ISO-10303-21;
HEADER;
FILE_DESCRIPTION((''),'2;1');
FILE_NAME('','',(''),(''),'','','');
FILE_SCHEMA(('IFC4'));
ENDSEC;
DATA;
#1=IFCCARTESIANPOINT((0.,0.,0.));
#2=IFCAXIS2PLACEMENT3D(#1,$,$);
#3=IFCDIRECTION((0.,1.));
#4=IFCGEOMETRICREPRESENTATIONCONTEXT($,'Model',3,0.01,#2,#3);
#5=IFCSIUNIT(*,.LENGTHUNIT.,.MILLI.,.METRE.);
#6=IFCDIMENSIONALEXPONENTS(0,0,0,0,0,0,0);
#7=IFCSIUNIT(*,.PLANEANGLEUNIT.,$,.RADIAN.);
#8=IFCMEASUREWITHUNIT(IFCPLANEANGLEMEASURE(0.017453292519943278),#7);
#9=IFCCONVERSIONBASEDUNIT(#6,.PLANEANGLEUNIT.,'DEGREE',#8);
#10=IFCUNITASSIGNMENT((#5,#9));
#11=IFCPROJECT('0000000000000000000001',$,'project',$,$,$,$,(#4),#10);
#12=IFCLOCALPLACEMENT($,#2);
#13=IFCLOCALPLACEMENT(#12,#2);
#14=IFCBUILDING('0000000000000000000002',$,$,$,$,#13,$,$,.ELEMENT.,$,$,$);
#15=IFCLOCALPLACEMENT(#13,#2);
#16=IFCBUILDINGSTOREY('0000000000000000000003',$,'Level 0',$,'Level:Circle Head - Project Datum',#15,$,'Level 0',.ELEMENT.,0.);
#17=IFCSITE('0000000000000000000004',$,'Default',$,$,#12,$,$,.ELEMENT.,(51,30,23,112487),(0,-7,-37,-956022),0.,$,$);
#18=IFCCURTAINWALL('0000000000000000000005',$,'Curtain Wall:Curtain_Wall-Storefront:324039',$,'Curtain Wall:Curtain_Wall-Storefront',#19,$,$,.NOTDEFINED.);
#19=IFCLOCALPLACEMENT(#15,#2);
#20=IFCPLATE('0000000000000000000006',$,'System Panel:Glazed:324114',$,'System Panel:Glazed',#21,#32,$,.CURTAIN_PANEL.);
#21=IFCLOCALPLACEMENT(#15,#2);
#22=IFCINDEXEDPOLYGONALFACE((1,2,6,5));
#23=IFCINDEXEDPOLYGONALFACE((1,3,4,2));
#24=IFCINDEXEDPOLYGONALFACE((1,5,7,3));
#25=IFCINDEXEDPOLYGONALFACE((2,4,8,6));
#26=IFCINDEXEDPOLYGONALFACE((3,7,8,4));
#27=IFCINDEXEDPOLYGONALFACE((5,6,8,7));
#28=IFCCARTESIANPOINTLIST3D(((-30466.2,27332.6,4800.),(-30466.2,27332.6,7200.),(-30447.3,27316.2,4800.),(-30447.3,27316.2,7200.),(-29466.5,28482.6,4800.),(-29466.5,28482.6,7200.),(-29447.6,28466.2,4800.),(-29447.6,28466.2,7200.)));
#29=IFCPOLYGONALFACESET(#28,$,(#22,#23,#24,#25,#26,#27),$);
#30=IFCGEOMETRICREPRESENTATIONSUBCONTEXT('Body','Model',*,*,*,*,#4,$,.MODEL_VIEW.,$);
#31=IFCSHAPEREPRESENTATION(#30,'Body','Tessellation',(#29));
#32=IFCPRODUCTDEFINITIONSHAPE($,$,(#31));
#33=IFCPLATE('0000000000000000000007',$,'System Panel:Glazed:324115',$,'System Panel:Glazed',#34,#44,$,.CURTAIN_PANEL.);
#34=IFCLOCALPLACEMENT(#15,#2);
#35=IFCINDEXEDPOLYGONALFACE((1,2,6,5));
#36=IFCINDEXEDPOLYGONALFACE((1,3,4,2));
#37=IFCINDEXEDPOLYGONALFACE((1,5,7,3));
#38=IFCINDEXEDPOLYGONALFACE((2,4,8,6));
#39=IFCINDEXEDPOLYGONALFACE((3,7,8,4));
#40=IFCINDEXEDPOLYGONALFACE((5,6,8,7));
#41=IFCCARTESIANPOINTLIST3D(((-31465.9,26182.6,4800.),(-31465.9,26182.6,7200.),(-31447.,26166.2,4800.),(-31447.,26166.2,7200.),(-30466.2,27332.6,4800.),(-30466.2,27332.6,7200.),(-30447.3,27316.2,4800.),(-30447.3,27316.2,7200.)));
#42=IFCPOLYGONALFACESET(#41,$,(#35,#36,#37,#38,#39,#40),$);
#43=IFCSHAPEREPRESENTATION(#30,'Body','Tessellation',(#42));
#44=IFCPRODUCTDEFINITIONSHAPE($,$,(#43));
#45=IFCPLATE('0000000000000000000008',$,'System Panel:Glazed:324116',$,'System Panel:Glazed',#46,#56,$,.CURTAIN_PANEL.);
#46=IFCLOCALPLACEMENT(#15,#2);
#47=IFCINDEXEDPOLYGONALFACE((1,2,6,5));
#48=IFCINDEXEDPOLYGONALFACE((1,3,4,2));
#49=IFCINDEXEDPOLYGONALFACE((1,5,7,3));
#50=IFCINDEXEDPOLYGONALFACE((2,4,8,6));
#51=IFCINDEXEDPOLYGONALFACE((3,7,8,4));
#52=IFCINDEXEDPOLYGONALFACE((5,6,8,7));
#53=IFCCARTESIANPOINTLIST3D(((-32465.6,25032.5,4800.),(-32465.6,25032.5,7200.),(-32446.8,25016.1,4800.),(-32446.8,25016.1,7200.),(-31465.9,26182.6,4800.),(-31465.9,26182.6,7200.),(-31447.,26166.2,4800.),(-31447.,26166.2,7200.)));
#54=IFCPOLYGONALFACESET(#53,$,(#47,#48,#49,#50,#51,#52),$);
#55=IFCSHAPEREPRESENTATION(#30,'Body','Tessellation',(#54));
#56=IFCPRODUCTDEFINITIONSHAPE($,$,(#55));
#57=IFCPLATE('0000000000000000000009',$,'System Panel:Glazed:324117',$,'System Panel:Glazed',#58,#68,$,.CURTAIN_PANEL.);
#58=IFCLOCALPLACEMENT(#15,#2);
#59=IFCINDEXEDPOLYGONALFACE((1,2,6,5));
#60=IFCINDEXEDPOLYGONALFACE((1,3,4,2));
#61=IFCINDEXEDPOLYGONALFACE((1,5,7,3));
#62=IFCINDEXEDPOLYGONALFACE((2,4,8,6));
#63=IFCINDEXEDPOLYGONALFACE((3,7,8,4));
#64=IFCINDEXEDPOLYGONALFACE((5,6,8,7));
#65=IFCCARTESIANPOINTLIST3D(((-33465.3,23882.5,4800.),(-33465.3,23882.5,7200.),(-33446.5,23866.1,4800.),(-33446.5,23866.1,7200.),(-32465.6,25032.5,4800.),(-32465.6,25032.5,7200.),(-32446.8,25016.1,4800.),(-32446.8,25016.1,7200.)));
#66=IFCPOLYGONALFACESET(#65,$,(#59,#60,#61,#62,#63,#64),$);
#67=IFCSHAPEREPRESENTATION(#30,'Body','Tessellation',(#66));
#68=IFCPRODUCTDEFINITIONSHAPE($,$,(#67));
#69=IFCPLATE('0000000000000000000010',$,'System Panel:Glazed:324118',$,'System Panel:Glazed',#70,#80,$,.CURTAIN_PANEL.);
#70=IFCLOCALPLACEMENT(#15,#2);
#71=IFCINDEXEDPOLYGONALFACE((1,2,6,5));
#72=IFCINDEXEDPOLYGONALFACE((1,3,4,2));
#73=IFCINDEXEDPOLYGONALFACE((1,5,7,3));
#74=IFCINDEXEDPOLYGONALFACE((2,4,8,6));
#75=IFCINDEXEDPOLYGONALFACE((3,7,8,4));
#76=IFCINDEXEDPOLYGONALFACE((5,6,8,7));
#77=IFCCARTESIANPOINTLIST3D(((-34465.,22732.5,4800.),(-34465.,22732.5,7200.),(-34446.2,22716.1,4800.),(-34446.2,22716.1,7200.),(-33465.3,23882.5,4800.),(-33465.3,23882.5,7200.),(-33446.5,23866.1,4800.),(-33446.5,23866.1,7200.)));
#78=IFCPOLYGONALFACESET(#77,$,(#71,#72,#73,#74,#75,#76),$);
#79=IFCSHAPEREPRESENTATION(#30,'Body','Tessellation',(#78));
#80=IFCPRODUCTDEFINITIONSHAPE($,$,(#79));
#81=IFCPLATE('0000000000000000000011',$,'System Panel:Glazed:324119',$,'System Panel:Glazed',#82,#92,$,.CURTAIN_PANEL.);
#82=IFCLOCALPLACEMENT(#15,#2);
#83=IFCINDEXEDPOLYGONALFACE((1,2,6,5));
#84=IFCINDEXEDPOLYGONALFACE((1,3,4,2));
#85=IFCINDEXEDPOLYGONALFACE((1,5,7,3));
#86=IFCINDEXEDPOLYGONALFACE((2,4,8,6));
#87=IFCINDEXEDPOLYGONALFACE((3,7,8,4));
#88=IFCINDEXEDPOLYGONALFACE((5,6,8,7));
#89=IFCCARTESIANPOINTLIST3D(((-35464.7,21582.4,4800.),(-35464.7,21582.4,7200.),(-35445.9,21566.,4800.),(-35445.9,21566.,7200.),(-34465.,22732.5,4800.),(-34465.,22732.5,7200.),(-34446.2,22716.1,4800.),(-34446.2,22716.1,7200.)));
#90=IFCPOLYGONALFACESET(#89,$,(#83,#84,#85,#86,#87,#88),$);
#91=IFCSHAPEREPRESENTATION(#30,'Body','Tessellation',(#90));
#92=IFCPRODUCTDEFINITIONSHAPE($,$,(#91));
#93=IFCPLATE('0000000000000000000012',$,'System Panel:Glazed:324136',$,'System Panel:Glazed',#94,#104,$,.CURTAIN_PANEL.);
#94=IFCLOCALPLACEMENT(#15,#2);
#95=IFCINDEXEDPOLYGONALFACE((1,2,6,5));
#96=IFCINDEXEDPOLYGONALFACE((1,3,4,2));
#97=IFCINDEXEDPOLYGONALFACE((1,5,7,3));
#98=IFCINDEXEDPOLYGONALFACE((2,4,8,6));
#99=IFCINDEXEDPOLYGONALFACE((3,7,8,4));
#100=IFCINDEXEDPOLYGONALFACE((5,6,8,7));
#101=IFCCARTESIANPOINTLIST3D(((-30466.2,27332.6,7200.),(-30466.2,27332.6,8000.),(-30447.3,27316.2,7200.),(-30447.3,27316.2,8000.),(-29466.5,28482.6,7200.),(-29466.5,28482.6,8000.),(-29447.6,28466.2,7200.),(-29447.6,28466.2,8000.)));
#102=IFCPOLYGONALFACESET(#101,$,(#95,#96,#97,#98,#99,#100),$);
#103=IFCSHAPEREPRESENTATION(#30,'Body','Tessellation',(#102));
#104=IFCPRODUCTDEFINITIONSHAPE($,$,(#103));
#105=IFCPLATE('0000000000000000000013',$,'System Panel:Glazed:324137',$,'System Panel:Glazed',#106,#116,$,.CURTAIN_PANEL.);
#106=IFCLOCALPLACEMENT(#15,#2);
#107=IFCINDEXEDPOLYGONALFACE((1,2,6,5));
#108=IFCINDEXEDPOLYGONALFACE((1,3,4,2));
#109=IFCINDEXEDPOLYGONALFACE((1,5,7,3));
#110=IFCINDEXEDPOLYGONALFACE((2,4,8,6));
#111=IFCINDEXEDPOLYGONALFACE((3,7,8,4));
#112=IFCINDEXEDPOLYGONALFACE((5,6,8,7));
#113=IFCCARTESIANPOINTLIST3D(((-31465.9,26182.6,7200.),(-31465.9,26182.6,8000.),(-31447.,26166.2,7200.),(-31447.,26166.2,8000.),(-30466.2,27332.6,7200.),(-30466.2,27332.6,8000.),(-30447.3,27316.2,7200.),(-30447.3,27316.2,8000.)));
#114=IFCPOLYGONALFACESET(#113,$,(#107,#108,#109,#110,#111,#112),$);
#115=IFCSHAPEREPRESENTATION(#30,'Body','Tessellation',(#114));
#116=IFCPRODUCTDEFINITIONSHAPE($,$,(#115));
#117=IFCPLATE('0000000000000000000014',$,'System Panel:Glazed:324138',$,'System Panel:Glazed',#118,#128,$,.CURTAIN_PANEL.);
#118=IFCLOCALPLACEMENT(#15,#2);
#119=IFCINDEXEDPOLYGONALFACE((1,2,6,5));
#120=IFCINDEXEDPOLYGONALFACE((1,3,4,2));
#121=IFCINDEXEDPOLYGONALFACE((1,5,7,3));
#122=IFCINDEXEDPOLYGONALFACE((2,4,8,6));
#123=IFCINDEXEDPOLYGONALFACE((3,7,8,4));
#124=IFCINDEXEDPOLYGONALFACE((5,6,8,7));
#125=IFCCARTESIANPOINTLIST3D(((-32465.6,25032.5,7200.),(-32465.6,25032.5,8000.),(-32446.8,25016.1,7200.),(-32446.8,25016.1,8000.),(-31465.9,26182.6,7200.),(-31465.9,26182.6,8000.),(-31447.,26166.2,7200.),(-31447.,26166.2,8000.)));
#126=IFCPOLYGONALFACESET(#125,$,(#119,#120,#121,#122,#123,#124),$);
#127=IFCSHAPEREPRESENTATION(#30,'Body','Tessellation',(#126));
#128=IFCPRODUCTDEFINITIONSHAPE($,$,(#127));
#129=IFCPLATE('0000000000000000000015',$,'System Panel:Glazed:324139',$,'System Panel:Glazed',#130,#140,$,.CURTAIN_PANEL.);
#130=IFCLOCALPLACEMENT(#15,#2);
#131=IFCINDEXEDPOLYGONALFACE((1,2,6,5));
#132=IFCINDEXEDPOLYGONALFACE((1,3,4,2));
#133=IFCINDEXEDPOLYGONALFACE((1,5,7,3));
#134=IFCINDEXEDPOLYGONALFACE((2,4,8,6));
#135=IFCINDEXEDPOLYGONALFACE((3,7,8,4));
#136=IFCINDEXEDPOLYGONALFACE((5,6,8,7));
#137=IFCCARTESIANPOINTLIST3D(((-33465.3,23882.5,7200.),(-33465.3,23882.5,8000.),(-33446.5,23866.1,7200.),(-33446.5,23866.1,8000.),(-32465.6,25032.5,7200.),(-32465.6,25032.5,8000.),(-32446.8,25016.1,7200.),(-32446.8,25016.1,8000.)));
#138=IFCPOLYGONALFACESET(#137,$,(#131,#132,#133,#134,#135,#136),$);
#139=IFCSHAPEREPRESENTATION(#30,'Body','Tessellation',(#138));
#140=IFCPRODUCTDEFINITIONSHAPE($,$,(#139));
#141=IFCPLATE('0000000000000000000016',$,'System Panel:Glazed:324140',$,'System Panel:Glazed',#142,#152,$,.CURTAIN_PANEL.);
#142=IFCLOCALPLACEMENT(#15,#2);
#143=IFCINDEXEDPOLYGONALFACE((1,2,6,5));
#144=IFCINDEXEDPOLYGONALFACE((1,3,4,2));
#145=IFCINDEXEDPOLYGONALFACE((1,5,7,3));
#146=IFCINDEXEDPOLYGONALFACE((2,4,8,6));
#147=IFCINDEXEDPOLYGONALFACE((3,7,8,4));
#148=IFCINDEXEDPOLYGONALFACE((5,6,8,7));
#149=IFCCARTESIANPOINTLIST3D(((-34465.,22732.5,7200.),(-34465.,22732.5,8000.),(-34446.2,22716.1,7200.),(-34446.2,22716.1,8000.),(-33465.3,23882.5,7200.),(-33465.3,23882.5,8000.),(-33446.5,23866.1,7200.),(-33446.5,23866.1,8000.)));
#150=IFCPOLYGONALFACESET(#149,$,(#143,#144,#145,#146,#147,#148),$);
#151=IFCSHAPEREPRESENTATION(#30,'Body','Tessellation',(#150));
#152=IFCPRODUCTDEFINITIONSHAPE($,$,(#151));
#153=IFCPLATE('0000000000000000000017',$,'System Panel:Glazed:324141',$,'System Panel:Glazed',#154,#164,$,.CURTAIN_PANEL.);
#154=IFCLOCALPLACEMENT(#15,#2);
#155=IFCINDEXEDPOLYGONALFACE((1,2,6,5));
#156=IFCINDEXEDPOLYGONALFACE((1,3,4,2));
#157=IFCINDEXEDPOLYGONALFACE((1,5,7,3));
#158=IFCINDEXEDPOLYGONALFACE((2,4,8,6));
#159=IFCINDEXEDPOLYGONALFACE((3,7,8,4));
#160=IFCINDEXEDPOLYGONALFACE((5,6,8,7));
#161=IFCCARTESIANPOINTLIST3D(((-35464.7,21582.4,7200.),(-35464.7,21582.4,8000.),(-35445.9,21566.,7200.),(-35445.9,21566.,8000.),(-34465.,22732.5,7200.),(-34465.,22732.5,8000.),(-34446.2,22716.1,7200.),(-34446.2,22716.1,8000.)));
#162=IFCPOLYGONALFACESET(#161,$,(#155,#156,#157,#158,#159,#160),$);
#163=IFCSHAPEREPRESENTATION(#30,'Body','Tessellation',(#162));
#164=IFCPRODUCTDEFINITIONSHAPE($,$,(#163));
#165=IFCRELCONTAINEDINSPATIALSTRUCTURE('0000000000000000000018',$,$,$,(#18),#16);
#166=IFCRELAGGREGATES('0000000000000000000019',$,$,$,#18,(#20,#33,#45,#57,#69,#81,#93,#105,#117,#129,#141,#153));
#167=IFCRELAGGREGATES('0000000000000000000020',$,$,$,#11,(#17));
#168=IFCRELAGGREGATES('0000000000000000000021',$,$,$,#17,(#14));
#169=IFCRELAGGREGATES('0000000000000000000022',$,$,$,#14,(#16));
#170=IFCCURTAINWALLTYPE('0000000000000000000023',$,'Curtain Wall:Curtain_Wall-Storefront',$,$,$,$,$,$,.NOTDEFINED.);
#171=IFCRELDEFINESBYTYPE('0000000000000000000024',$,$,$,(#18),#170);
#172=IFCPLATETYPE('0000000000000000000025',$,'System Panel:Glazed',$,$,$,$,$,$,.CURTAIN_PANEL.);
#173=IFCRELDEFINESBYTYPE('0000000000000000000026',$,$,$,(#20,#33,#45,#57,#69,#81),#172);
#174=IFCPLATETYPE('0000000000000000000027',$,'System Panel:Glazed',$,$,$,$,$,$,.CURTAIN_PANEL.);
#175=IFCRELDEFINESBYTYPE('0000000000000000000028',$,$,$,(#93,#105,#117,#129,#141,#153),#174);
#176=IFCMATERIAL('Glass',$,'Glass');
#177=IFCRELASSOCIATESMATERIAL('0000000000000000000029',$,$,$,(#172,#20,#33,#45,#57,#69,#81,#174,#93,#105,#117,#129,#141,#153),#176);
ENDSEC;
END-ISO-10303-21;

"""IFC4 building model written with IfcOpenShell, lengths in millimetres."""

from ifc_helpers import new_model, entity, si_unit, converted_unit, direction, frame, origin, place, context, subcontext, project, spatial, indexed_curve, outline, extrude, source, transform, mapped, material, type_object, type_shapes, element, aggregate, save


model = new_model("IFC4")

# Units and contexts
model_context = context("Model", 3, precision=0.01, world=origin(), true_north=direction((0.0, 1.0)))
body_context = subcontext(model_context, "Body", "Model", "MODEL_VIEW")
ifc_project = project(units=[si_unit("LENGTHUNIT", "METRE", prefix="MILLI"), converted_unit("PLANEANGLEUNIT", "DEGREE", entity("IfcPlaneAngleMeasure", 0.017453292519943278), si_unit("PLANEANGLEUNIT", "RADIAN"), dimensions=[0, 0, 0, 0, 0, 0, 0])], contexts=[model_context])

# Site, building, storey
site_placement = place(None, origin())
site = spatial("IfcSite", under=ifc_project, at=site_placement, Name="Default", CompositionType="ELEMENT", RefLatitude=(51, 30, 23, 112487), RefLongitude=(0, -7, -37, -956022), RefElevation=0.0)
building_placement = place(site_placement, origin())
building = spatial("IfcBuilding", under=site, at=building_placement, CompositionType="ELEMENT")
storey_placement = place(building_placement, origin())
storey = spatial("IfcBuildingStorey", under=building, at=storey_placement, Name="Level 0", ObjectType="Level:Circle Head - Project Datum", LongName="Level 0", CompositionType="ELEMENT", Elevation=0.0)

# Curtain wall, plates
curtain_wall_type = type_object("IfcCurtainWallType", Name="Curtain Wall:Curtain_Wall-Storefront", PredefinedType="NOTDEFINED")
curtain_wall_placement = place(storey_placement, origin())
curtain_wall = element("IfcCurtainWall", 1, at=curtain_wall_placement, inside=storey, type_object=curtain_wall_type, Name="Curtain Wall:Curtain_Wall-Storefront:324039", ObjectType="Curtain Wall:Curtain_Wall-Storefront", PredefinedType="NOTDEFINED")
ifc_material = material(Name="Glass", Category="Glass")
plate_type_1 = type_object("IfcPlateType", Name="System Panel:Glazed", PredefinedType="CURTAIN_PANEL", material=ifc_material)
shared_shape_1 = source(origin(), body_context, "Body", "SweptSolid", [
    extrude(outline(indexed_curve([(-12.5, -761.9), (12.5, -761.9), (12.5, 761.9), (-12.5, 761.9), (-12.5, -761.9)], self_intersect=False)), frame((0.0, 37.0, 0.0), z_axis=(0.0, 0.0, 1.0), x_axis=(0.0, 1.0, 0.0)), (0.0, 0.0, 1.0), 2400.0),
])
type_shapes(plate_type_1, [shared_shape_1])
plate_1_placement = place(curtain_wall_placement, frame((-29984.8, 27923.7, 4800.0), z_axis=(0.0, 0.0, 1.0), x_axis=(-0.656059, -0.75471, 0.0)))
plate_1 = element("IfcPlate", 2, at=plate_1_placement, type_object=plate_type_1, material=ifc_material, Name="System Panel:Glazed:324114", ObjectType="System Panel:Glazed", PredefinedType="CURTAIN_PANEL", context=body_context, shape_type="MappedRepresentation", body=[
    mapped(shared_shape_1, transform((0.0, 0.0, 0.0), scale=1.0)),
])
plate_2_placement = place(curtain_wall_placement, frame((-30984.5, 26773.7, 4800.0), z_axis=(0.0, 0.0, 1.0), x_axis=(-0.656059, -0.75471, 0.0)))
plate_2 = element("IfcPlate", 3, at=plate_2_placement, type_object=plate_type_1, material=ifc_material, Name="System Panel:Glazed:324115", ObjectType="System Panel:Glazed", PredefinedType="CURTAIN_PANEL", context=body_context, shape_type="MappedRepresentation", body=[
    mapped(shared_shape_1, transform((0.0, 0.0, 0.0), scale=1.0)),
])
plate_3_placement = place(curtain_wall_placement, frame((-31984.3, 25623.6, 4800.0), z_axis=(0.0, 0.0, 1.0), x_axis=(-0.656059, -0.75471, 0.0)))
plate_3 = element("IfcPlate", 4, at=plate_3_placement, type_object=plate_type_1, material=ifc_material, Name="System Panel:Glazed:324116", ObjectType="System Panel:Glazed", PredefinedType="CURTAIN_PANEL", context=body_context, shape_type="MappedRepresentation", body=[
    mapped(shared_shape_1, transform((0.0, 0.0, 0.0), scale=1.0)),
])
plate_4_placement = place(curtain_wall_placement, frame((-32984.0, 24473.6, 4800.0), z_axis=(0.0, 0.0, 1.0), x_axis=(-0.656059, -0.75471, 0.0)))
plate_4 = element("IfcPlate", 5, at=plate_4_placement, type_object=plate_type_1, material=ifc_material, Name="System Panel:Glazed:324117", ObjectType="System Panel:Glazed", PredefinedType="CURTAIN_PANEL", context=body_context, shape_type="MappedRepresentation", body=[
    mapped(shared_shape_1, transform((0.0, 0.0, 0.0), scale=1.0)),
])
plate_5_placement = place(curtain_wall_placement, frame((-33983.7, 23323.6, 4800.0), z_axis=(0.0, 0.0, 1.0), x_axis=(-0.656059, -0.75471, 0.0)))
plate_5 = element("IfcPlate", 6, at=plate_5_placement, type_object=plate_type_1, material=ifc_material, Name="System Panel:Glazed:324118", ObjectType="System Panel:Glazed", PredefinedType="CURTAIN_PANEL", context=body_context, shape_type="MappedRepresentation", body=[
    mapped(shared_shape_1, transform((0.0, 0.0, 0.0), scale=1.0)),
])
plate_6_placement = place(curtain_wall_placement, frame((-34983.4, 22173.5, 4800.0), z_axis=(0.0, 0.0, 1.0), x_axis=(-0.656059, -0.75471, 0.0)))
plate_6 = element("IfcPlate", 7, at=plate_6_placement, type_object=plate_type_1, material=ifc_material, Name="System Panel:Glazed:324119", ObjectType="System Panel:Glazed", PredefinedType="CURTAIN_PANEL", context=body_context, shape_type="MappedRepresentation", body=[
    mapped(shared_shape_1, transform((0.0, 0.0, 0.0), scale=1.0)),
])
plate_type_2 = type_object("IfcPlateType", Name="System Panel:Glazed", PredefinedType="CURTAIN_PANEL", material=ifc_material)
shared_shape_2 = source(origin(), body_context, "Body", "SweptSolid", [
    extrude(outline(indexed_curve([(-12.5, -761.9), (12.5, -761.9), (12.5, 761.9), (-12.5, 761.9), (-12.5, -761.9)], self_intersect=False)), frame((0.0, 37.0, 0.0), z_axis=(0.0, 0.0, 1.0), x_axis=(0.0, 1.0, 0.0)), (0.0, 0.0, 1.0), 800.0),
])
type_shapes(plate_type_2, [shared_shape_2])
plate_7_placement = place(curtain_wall_placement, frame((-29984.8, 27923.7, 7200.0), z_axis=(0.0, 0.0, 1.0), x_axis=(-0.656059, -0.75471, 0.0)))
plate_7 = element("IfcPlate", 8, at=plate_7_placement, type_object=plate_type_2, material=ifc_material, Name="System Panel:Glazed:324136", ObjectType="System Panel:Glazed", PredefinedType="CURTAIN_PANEL", context=body_context, shape_type="MappedRepresentation", body=[
    mapped(shared_shape_2, transform((0.0, 0.0, 0.0), scale=1.0)),
])
plate_8_placement = place(curtain_wall_placement, frame((-30984.5, 26773.7, 7200.0), z_axis=(0.0, 0.0, 1.0), x_axis=(-0.656059, -0.75471, 0.0)))
plate_8 = element("IfcPlate", 9, at=plate_8_placement, type_object=plate_type_2, material=ifc_material, Name="System Panel:Glazed:324137", ObjectType="System Panel:Glazed", PredefinedType="CURTAIN_PANEL", context=body_context, shape_type="MappedRepresentation", body=[
    mapped(shared_shape_2, transform((0.0, 0.0, 0.0), scale=1.0)),
])
plate_9_placement = place(curtain_wall_placement, frame((-31984.3, 25623.6, 7200.0), z_axis=(0.0, 0.0, 1.0), x_axis=(-0.656059, -0.75471, 0.0)))
plate_9 = element("IfcPlate", 10, at=plate_9_placement, type_object=plate_type_2, material=ifc_material, Name="System Panel:Glazed:324138", ObjectType="System Panel:Glazed", PredefinedType="CURTAIN_PANEL", context=body_context, shape_type="MappedRepresentation", body=[
    mapped(shared_shape_2, transform((0.0, 0.0, 0.0), scale=1.0)),
])
plate_10_placement = place(curtain_wall_placement, frame((-32984.0, 24473.6, 7200.0), z_axis=(0.0, 0.0, 1.0), x_axis=(-0.656059, -0.75471, 0.0)))
plate_10 = element("IfcPlate", 11, at=plate_10_placement, type_object=plate_type_2, material=ifc_material, Name="System Panel:Glazed:324139", ObjectType="System Panel:Glazed", PredefinedType="CURTAIN_PANEL", context=body_context, shape_type="MappedRepresentation", body=[
    mapped(shared_shape_2, transform((0.0, 0.0, 0.0), scale=1.0)),
])
plate_11_placement = place(curtain_wall_placement, frame((-33983.7, 23323.6, 7200.0), z_axis=(0.0, 0.0, 1.0), x_axis=(-0.656059, -0.75471, 0.0)))
plate_11 = element("IfcPlate", 12, at=plate_11_placement, type_object=plate_type_2, material=ifc_material, Name="System Panel:Glazed:324140", ObjectType="System Panel:Glazed", PredefinedType="CURTAIN_PANEL", context=body_context, shape_type="MappedRepresentation", body=[
    mapped(shared_shape_2, transform((0.0, 0.0, 0.0), scale=1.0)),
])
plate_12_placement = place(curtain_wall_placement, frame((-34983.4, 22173.5, 7200.0), z_axis=(0.0, 0.0, 1.0), x_axis=(-0.656059, -0.75471, 0.0)))
plate_12 = element("IfcPlate", 13, at=plate_12_placement, type_object=plate_type_2, material=ifc_material, Name="System Panel:Glazed:324141", ObjectType="System Panel:Glazed", PredefinedType="CURTAIN_PANEL", context=body_context, shape_type="MappedRepresentation", body=[
    mapped(shared_shape_2, transform((0.0, 0.0, 0.0), scale=1.0)),
])
aggregate(curtain_wall, [plate_1, plate_2, plate_3, plate_4, plate_5, plate_6, plate_7, plate_8, plate_9, plate_10, plate_11, plate_12])

save(model, "model.ifc")
